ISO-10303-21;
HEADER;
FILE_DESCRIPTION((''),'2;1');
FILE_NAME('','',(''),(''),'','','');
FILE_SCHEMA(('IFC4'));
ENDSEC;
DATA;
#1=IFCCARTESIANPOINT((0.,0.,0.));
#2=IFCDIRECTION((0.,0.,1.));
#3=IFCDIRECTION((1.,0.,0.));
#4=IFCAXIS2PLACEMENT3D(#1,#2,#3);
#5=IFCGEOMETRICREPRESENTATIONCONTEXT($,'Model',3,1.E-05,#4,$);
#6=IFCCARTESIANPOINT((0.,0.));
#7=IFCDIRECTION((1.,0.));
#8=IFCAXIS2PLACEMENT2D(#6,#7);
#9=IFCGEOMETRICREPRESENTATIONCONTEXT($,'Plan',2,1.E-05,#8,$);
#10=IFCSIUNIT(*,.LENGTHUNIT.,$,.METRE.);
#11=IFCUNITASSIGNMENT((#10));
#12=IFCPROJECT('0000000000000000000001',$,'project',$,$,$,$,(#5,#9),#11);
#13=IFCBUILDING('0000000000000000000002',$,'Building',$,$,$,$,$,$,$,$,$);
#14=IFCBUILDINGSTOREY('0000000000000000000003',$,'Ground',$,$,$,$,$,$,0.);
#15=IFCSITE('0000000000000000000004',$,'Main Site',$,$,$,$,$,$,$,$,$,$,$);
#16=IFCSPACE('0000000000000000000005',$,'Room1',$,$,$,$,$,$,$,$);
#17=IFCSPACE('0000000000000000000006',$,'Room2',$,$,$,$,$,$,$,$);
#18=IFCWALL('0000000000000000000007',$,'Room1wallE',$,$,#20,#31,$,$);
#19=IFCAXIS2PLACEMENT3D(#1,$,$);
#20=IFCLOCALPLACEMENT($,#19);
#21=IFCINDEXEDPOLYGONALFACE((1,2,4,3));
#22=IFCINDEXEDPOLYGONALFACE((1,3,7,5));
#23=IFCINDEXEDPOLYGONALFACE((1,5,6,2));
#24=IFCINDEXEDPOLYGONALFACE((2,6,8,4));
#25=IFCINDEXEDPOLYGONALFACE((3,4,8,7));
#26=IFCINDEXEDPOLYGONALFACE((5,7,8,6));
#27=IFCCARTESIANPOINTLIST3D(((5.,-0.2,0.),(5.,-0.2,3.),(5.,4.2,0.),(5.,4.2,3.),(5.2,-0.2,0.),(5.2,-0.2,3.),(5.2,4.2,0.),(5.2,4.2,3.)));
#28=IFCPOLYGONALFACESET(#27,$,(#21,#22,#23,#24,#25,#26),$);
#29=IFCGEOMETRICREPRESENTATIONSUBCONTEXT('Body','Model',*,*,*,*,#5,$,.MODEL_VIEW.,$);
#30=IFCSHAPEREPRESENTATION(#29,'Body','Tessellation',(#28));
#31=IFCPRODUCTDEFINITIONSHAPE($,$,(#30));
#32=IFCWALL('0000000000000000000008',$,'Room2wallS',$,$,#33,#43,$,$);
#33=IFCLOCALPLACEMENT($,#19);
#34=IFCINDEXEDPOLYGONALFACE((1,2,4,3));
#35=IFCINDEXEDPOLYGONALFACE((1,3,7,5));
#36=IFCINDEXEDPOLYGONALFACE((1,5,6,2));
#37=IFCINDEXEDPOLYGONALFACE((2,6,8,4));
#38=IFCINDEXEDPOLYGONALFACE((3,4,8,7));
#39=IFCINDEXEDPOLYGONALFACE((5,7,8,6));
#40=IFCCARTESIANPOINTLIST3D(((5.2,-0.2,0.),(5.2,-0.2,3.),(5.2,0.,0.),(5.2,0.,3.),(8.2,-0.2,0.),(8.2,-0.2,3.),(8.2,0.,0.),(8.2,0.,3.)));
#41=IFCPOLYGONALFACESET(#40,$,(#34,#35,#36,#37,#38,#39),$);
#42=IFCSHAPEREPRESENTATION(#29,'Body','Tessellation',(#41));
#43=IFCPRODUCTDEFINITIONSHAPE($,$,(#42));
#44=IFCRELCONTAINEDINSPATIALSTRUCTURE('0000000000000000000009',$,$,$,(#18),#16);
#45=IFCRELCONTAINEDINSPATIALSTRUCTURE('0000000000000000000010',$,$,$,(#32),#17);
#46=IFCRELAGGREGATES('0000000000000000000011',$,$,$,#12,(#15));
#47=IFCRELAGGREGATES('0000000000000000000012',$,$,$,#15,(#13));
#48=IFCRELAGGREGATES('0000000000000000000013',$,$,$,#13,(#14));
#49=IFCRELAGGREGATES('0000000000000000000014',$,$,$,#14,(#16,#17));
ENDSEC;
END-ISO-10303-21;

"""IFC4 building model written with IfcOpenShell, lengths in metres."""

from ifc_helpers import new_model, si_unit, frame, origin_with_axes, origin_2d_with_axis, place, context, subcontext, project, spatial, indexed_curve, outline, extrude, element, save


model = new_model("IFC4")

# Units and contexts
model_context = context("Model", 3, precision=1e-05, world=origin_with_axes())
plan_context = context("Plan", 2, precision=1e-05, world=origin_2d_with_axis())
body_context = subcontext(model_context, "Body", "Model", "MODEL_VIEW")
ifc_project = project(units=[si_unit("LENGTHUNIT", "METRE")], contexts=[model_context, plan_context])

# Site, building, storey, space
site = spatial("IfcSite", under=ifc_project, Name="Main Site")
building = spatial("IfcBuilding", under=site, Name="Building")
storey = spatial("IfcBuildingStorey", under=building, Name="Ground", Elevation=0.0)
space_1 = spatial("IfcSpace", under=storey, Name="Room1")

# Wall
wall_1_placement = place(None, frame((5.2, -0.2, 0.0), z_axis=(0.0, 0.0, 1.0), x_axis=(0.0, 1.0, 0.0)))
element("IfcWall", 1, at=wall_1_placement, inside=space_1, Name="Room1wallE", context=body_context, shape_type="SweptSolid", body=[
    extrude(outline(indexed_curve([(0.0, 0.0), (0.0, 0.2), (4.4, 0.2), (4.4, 0.0), (0.0, 0.0)], self_intersect=False)), origin_with_axes(), (0.0, 0.0, 1.0), 3.0),
])

# Shared definitions
space_2 = spatial("IfcSpace", under=storey, Name="Room2")

# Wall
wall_2_placement = place(None, frame((5.2, -0.2, 0.0), z_axis=(0.0, 0.0, 1.0), x_axis=(1.0, 0.0, 0.0)))
element("IfcWall", 2, at=wall_2_placement, inside=space_2, Name="Room2wallS", context=body_context, shape_type="SweptSolid", body=[
    extrude(outline(indexed_curve([(0.0, 0.0), (0.0, 0.2), (3.0, 0.2), (3.0, 0.0), (0.0, 0.0)], self_intersect=False)), origin_with_axes(), (0.0, 0.0, 1.0), 3.0),
])

save(model, "model.ifc")
